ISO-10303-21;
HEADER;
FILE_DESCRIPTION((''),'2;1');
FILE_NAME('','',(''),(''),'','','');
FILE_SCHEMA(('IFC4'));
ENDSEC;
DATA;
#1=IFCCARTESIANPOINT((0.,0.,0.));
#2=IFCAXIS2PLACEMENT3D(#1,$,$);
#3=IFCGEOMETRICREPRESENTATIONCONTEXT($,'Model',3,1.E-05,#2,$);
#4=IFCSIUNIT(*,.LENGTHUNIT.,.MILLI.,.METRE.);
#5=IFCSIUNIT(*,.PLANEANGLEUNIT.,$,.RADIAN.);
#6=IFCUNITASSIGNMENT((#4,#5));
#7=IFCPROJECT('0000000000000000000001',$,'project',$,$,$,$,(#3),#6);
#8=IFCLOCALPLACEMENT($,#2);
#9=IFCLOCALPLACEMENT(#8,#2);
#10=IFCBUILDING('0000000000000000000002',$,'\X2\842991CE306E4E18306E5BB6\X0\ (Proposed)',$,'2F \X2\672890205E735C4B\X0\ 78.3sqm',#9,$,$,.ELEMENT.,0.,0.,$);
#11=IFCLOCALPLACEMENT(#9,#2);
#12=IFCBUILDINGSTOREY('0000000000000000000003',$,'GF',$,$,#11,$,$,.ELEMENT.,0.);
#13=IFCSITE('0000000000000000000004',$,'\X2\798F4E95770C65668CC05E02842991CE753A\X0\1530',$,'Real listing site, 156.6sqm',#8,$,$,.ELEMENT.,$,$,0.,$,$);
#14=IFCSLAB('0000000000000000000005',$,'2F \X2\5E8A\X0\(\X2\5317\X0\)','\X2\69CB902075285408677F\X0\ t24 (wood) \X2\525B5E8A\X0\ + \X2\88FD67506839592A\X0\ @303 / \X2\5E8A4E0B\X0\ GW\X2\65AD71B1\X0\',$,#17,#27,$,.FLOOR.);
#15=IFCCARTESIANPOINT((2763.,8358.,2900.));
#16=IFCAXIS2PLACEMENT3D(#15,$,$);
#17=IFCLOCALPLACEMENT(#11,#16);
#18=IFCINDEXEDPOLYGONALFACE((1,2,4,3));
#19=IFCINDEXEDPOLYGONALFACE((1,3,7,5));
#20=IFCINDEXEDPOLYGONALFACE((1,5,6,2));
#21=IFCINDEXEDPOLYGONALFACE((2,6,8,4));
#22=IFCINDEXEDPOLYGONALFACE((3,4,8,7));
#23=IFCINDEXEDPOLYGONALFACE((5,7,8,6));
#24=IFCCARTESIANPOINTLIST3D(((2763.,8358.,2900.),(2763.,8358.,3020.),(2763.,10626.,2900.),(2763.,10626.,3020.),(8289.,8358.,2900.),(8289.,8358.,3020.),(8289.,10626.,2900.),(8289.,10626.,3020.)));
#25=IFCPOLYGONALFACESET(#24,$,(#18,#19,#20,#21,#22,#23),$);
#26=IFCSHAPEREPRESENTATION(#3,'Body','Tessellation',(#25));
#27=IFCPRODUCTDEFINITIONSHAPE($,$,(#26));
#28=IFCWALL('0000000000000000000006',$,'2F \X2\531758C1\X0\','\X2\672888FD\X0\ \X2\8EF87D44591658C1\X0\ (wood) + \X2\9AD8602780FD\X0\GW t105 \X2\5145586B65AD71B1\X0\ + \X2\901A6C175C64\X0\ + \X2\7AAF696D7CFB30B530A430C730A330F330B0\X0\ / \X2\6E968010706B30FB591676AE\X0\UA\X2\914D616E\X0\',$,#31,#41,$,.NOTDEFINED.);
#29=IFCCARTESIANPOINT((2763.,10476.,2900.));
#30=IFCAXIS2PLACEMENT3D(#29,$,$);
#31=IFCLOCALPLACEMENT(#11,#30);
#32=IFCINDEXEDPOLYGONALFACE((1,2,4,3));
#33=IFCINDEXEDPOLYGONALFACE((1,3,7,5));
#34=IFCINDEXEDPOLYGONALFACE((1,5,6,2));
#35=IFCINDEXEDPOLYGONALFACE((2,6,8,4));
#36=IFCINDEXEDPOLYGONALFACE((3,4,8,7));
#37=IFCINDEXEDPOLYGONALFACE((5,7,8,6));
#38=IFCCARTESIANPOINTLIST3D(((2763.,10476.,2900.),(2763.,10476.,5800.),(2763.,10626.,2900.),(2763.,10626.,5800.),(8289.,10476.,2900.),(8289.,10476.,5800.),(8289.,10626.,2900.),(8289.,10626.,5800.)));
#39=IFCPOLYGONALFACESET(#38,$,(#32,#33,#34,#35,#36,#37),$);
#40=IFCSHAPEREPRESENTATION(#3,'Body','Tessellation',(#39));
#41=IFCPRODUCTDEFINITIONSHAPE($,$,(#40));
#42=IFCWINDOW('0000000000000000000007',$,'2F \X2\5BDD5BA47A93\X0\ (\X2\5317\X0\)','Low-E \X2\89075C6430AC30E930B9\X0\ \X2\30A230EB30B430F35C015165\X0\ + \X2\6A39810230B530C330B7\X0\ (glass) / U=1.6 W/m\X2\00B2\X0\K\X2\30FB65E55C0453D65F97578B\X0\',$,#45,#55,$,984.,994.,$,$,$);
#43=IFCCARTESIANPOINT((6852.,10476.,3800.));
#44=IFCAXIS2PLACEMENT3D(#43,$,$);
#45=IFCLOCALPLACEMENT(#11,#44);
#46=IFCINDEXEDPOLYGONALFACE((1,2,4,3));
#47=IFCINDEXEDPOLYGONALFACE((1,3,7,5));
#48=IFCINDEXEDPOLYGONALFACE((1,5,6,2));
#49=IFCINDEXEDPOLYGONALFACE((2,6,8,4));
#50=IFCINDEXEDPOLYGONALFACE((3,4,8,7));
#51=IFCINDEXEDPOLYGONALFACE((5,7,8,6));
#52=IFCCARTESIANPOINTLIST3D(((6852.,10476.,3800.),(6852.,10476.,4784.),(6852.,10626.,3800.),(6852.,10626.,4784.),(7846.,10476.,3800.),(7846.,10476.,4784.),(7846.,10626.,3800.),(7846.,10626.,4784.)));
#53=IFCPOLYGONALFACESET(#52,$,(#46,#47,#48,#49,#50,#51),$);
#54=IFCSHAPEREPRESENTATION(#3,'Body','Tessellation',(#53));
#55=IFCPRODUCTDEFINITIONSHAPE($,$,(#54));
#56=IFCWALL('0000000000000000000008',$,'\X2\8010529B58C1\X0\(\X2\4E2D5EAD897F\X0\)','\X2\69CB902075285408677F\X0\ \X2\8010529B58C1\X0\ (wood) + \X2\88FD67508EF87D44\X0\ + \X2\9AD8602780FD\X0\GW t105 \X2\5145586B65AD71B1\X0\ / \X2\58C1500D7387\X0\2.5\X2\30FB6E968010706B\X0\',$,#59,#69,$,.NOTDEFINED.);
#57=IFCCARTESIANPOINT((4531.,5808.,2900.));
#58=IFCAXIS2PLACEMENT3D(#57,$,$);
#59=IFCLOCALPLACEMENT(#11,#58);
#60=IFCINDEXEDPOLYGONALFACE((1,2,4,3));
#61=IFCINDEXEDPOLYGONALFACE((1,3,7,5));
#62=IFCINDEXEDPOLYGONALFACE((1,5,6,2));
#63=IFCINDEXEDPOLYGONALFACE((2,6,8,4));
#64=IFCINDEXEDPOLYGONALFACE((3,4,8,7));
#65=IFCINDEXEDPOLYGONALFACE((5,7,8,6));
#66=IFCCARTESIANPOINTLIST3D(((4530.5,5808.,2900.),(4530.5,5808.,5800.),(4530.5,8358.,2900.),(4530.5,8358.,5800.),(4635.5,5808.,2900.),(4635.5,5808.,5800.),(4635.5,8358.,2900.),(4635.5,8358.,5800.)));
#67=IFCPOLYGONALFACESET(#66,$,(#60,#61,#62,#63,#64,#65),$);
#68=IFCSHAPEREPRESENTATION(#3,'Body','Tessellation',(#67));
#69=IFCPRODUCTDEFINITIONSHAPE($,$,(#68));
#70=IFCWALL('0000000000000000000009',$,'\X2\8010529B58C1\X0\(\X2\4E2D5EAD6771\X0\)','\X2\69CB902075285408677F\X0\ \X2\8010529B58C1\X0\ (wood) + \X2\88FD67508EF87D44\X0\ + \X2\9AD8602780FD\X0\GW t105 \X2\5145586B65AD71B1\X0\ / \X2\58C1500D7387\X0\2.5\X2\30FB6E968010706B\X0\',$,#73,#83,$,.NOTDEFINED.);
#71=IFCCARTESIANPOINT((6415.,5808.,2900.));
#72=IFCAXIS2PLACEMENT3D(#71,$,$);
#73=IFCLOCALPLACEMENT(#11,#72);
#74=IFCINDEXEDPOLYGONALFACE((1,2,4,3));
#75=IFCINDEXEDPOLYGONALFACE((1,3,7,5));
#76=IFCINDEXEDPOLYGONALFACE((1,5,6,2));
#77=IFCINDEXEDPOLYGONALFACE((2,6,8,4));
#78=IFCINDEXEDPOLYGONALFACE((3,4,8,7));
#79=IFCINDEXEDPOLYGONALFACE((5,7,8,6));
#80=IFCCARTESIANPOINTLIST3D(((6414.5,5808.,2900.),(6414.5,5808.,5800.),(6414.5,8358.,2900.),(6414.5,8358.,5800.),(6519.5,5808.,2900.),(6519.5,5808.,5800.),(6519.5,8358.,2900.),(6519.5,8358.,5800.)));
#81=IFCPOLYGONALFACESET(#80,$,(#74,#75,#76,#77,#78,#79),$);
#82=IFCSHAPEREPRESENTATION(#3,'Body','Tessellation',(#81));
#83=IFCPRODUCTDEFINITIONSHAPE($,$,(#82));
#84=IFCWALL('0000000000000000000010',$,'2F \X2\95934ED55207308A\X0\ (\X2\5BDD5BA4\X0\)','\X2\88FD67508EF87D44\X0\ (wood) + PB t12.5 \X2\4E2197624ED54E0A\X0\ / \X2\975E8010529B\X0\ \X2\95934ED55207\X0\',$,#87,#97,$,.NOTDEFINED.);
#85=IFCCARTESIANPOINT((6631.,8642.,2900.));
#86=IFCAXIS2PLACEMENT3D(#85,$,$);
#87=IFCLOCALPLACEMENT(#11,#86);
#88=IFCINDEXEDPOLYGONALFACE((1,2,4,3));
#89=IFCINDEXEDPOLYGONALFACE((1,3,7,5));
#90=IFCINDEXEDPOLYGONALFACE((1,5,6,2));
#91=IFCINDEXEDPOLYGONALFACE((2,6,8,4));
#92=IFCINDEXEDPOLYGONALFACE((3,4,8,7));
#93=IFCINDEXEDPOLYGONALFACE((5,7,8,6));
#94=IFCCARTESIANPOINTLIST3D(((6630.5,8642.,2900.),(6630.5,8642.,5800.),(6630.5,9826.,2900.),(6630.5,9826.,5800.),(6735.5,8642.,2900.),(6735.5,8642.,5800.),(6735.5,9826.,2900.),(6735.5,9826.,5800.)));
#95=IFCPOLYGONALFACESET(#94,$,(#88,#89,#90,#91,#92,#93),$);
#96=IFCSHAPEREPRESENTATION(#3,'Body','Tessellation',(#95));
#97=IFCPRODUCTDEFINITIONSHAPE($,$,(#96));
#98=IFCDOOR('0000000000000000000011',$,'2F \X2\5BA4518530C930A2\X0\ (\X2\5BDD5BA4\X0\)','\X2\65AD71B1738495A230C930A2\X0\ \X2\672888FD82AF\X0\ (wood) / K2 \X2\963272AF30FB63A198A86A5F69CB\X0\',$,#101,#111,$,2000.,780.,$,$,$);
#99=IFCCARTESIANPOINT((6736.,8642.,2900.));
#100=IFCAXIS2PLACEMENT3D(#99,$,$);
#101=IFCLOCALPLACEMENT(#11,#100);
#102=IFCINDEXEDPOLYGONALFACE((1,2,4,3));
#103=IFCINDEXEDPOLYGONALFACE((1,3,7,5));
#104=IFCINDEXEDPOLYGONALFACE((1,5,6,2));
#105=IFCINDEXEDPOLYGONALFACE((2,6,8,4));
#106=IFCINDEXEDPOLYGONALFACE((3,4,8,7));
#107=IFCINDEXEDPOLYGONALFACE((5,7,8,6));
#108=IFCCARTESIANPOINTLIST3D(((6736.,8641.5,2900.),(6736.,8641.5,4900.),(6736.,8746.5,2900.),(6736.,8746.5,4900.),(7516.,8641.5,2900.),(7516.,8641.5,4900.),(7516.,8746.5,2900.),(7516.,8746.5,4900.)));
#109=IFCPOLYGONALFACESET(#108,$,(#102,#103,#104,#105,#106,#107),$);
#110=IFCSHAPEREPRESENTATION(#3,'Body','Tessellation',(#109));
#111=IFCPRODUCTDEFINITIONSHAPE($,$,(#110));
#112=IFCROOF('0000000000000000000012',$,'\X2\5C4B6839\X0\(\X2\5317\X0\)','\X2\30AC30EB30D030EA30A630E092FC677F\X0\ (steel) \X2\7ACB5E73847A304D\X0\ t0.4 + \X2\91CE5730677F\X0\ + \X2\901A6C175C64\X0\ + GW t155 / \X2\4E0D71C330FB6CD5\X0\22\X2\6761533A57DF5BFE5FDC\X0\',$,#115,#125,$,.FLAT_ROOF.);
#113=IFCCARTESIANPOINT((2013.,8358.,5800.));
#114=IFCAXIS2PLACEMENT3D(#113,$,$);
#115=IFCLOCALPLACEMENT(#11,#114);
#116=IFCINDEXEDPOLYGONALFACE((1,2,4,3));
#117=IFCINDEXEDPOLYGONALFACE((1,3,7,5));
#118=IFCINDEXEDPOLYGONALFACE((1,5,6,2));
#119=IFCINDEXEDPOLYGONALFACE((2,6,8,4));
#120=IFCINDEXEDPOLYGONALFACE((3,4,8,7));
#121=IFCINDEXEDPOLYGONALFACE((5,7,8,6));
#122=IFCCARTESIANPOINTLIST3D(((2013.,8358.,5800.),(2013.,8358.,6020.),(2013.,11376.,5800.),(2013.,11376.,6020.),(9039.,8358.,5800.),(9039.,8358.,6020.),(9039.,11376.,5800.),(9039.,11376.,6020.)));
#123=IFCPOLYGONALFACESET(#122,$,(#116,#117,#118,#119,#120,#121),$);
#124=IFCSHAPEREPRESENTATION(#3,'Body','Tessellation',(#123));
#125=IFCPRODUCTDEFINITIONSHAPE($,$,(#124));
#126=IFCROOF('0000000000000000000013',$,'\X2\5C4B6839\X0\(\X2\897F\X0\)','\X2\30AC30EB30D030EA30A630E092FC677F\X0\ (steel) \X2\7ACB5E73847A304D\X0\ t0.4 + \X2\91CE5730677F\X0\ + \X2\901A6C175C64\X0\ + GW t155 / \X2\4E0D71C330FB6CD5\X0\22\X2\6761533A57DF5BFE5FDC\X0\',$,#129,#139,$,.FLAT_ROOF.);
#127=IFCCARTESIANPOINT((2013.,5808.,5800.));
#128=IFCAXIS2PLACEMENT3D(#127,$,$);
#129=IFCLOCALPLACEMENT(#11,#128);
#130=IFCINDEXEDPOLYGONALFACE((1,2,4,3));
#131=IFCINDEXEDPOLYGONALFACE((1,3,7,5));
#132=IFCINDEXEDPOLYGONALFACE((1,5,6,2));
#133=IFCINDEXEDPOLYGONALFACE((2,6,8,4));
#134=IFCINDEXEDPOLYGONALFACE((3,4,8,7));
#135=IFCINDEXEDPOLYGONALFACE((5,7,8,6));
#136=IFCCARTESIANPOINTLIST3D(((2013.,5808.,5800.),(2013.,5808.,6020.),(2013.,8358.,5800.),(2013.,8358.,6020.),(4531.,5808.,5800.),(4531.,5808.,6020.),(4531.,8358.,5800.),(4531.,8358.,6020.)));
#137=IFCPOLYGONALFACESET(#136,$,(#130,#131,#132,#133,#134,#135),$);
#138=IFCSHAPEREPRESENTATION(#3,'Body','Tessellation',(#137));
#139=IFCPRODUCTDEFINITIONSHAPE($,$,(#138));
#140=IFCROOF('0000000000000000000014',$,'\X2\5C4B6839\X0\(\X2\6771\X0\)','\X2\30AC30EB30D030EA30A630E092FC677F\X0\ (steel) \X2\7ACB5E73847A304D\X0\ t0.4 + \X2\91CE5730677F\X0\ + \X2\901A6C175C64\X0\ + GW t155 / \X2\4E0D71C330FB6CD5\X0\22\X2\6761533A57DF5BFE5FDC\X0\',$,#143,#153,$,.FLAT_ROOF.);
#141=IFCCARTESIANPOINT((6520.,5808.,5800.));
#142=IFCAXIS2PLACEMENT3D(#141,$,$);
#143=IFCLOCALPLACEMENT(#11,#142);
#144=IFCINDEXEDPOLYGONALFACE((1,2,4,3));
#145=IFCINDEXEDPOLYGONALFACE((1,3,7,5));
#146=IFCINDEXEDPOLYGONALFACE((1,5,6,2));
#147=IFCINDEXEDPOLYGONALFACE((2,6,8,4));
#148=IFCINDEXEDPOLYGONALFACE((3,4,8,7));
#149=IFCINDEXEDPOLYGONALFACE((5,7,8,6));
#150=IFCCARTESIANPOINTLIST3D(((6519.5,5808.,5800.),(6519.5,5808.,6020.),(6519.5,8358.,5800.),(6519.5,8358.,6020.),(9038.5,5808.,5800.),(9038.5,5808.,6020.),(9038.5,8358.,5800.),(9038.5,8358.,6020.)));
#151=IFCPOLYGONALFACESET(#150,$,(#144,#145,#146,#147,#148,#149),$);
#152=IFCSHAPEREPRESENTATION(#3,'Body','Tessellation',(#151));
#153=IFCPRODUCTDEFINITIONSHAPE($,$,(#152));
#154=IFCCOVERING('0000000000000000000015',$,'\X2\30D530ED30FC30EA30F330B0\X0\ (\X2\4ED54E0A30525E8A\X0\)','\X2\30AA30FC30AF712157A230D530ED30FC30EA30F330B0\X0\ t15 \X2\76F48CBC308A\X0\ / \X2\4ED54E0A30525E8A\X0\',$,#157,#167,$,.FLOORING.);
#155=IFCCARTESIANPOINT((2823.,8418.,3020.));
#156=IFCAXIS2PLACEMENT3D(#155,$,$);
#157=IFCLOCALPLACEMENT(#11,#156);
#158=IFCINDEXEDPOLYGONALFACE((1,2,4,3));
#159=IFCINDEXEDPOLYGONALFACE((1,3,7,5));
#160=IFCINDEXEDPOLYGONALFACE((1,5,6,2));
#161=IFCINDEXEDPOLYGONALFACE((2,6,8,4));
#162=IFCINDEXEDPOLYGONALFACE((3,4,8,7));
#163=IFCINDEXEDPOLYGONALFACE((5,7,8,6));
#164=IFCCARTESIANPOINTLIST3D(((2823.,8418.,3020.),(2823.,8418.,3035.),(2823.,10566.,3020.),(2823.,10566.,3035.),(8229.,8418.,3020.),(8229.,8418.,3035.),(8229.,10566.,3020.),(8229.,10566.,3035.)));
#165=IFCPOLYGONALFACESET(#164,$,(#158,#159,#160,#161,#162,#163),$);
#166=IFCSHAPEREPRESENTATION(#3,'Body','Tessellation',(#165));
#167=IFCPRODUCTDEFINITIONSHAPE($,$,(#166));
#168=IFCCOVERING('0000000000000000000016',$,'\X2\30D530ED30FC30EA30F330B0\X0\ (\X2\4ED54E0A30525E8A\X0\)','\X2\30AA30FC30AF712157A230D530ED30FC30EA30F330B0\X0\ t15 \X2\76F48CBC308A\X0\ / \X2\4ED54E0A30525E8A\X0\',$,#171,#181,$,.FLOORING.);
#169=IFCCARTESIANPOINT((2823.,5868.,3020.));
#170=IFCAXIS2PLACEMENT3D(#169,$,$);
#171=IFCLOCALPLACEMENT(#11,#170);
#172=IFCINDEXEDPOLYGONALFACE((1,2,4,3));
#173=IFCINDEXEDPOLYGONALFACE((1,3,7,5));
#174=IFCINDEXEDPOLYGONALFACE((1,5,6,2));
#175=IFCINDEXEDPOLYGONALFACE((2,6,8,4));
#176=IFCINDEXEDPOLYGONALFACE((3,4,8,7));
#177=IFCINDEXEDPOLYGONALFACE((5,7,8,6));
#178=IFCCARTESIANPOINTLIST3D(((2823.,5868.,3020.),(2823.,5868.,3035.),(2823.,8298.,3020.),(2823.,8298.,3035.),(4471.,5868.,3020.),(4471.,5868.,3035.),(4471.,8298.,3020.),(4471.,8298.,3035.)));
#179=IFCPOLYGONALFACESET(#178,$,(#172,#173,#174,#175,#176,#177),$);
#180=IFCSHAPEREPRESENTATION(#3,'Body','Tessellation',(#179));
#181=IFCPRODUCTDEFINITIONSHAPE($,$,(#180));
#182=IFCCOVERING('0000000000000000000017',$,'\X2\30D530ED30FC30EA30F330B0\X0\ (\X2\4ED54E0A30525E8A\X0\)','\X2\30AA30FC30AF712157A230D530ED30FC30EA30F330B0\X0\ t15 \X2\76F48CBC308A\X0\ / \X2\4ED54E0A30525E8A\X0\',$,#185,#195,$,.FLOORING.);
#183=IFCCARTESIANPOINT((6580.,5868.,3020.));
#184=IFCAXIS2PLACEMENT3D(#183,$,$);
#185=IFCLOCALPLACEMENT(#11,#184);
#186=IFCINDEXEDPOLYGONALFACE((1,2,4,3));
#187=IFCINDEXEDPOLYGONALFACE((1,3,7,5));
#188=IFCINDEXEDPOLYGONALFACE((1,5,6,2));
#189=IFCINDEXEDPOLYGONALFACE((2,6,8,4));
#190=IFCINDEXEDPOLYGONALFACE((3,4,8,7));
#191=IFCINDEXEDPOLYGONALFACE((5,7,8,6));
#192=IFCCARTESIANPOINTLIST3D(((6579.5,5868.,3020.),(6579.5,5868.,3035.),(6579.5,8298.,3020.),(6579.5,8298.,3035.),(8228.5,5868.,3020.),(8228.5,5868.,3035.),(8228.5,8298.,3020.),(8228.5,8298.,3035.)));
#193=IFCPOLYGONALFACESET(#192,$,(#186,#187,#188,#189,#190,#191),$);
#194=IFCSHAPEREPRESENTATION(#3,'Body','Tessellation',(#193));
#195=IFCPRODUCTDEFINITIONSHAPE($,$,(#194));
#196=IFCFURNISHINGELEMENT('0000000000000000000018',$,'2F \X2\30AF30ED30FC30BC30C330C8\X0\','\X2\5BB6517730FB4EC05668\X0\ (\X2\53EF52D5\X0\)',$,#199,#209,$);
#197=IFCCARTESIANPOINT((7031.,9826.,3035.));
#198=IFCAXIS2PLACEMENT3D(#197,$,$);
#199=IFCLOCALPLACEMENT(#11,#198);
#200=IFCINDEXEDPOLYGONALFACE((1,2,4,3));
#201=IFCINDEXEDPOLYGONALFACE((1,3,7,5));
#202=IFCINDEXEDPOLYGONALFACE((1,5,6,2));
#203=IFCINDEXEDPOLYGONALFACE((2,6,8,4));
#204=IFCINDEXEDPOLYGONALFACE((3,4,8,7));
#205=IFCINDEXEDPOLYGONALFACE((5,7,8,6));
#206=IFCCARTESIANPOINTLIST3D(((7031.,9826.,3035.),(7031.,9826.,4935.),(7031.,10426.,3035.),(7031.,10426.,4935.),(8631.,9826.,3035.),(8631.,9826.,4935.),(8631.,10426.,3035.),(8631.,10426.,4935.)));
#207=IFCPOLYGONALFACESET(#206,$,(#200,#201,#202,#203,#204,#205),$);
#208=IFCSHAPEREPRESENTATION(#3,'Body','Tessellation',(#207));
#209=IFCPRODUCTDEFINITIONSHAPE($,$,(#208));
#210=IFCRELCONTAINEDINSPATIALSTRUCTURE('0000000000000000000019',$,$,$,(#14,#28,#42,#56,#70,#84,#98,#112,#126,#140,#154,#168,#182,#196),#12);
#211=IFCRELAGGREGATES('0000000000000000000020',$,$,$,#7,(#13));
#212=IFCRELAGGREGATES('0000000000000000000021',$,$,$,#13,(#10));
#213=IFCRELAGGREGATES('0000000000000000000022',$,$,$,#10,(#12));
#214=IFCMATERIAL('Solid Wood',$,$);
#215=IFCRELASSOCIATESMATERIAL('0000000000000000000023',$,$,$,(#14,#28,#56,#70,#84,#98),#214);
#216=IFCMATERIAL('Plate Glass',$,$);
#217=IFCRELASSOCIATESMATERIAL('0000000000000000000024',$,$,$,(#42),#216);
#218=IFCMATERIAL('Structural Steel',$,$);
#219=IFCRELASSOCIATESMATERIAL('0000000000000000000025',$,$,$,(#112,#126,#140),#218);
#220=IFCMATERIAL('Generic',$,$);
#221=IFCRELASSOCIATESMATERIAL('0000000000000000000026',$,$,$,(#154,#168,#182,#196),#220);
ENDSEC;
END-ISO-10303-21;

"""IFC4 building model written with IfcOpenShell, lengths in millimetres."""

from ifc_helpers import new_model, si_unit, frame, frame_2d, origin, place, context, project, spatial, rectangle, extrude, material, element, fill, save


model = new_model("IFC4")

# Units and contexts
model_context = context("Model", 3, precision=1e-05, world=origin())
ifc_project = project(units=[si_unit("LENGTHUNIT", "METRE", prefix="MILLI"), si_unit("PLANEANGLEUNIT", "RADIAN")], contexts=[model_context])

# Site, building, storey
site_placement = place(None, origin())
site = spatial("IfcSite", under=ifc_project, at=site_placement, Name="福井県敦賀市萩野町1530", ObjectType="Real listing site, 156.6sqm", CompositionType="ELEMENT", RefElevation=0.0)
building_placement = place(site_placement, origin())
building = spatial("IfcBuilding", under=site, at=building_placement, Name="萩野の丘の家 (Proposed)", ObjectType="2F 木造平屋 78.3sqm", CompositionType="ELEMENT", ElevationOfRefHeight=0.0, ElevationOfTerrain=0.0)
storey_placement = place(building_placement, origin())
storey = spatial("IfcBuildingStorey", under=building, at=storey_placement, Name="GF", CompositionType="ELEMENT", Elevation=0.0)

# Slab
ifc_material_1 = material(Name="Solid Wood")
slab_placement = place(storey_placement, frame((2763.0, 8358.0, 2900.0)))
element("IfcSlab", 1, at=slab_placement, inside=storey, material=ifc_material_1, Name="2F 床(北)", Description="構造用合板 t24 (wood) 剛床 + 製材根太 @303 / 床下 GW断熱", PredefinedType="FLOOR", context=model_context, shape_type="SweptSolid", body=[
    extrude(rectangle(XDim=5526.0, YDim=2268.0, at=frame_2d((2763.0, 1134.0))), frame((2763.0, 8358.0, 2900.0)), (0.0, 0.0, 1.0), 120.0),
])

# Wall, opening, window
wall_1_placement = place(storey_placement, frame((2763.0, 10476.0, 2900.0)))
wall_1 = element("IfcWall", 2, at=wall_1_placement, inside=storey, material=ifc_material_1, Name="2F 北壁", Description="木製 軸組外壁 (wood) + 高性能GW t105 充填断熱 + 通気層 + 窯業系サイディング / 準耐火・外皮UA配慮", PredefinedType="NOTDEFINED", context=model_context, shape_type="SweptSolid", body=[
    extrude(rectangle(XDim=5526.0, YDim=150.0, at=frame_2d((2763.0, 75.0))), frame((2763.0, 10476.0, 2900.0)), (0.0, 0.0, 1.0), 2900.0),
])
opening_1_placement = place(storey_placement, frame((6852.0, 10476.0, 3800.0)))
opening_1 = element("IfcOpeningElement", 3, at=opening_1_placement, cuts=wall_1, PredefinedType="NOTDEFINED", context=model_context, shape_type="SweptSolid", body=[
    extrude(rectangle(XDim=994.0, YDim=150.0, at=frame_2d((497.0, 75.0))), frame((6852.0, 10476.0, 3800.0)), (0.0, 0.0, 1.0), 984.0),
])
ifc_material_2 = material(Name="Plate Glass")
window_1_placement = place(storey_placement, frame((6852.0, 10476.0, 3800.0)))
window_1 = element("IfcWindow", 4, at=window_1_placement, inside=storey, material=ifc_material_2, Name="2F 寝室窓 (北)", Description="Low-E 複層ガラス アルゴン封入 + 樹脂サッシ (glass) / U=1.6 W/m²K・日射取得型", OverallHeight=984.0, OverallWidth=994.0, context=model_context, shape_type="SweptSolid", body=[
    extrude(rectangle(XDim=994.0, YDim=150.0, at=frame_2d((497.0, 75.0))), frame((6852.0, 10476.0, 3800.0)), (0.0, 0.0, 1.0), 984.0),
])
fill(opening_1, window_1)

# Walls
wall_2_placement = place(storey_placement, frame((4531.0, 5808.0, 2900.0)))
element("IfcWall", 5, at=wall_2_placement, inside=storey, material=ifc_material_1, Name="耐力壁(中庭西)", Description="構造用合板 耐力壁 (wood) + 製材軸組 + 高性能GW t105 充填断熱 / 壁倍率2.5・準耐火", PredefinedType="NOTDEFINED", context=model_context, shape_type="SweptSolid", body=[
    extrude(rectangle(XDim=105.0, YDim=2550.0, at=frame_2d((52.0, 1275.0))), frame((4531.0, 5808.0, 2900.0)), (0.0, 0.0, 1.0), 2900.0),
])
wall_3_placement = place(storey_placement, frame((6415.0, 5808.0, 2900.0)))
element("IfcWall", 6, at=wall_3_placement, inside=storey, material=ifc_material_1, Name="耐力壁(中庭東)", Description="構造用合板 耐力壁 (wood) + 製材軸組 + 高性能GW t105 充填断熱 / 壁倍率2.5・準耐火", PredefinedType="NOTDEFINED", context=model_context, shape_type="SweptSolid", body=[
    extrude(rectangle(XDim=105.0, YDim=2550.0, at=frame_2d((52.0, 1275.0))), frame((6415.0, 5808.0, 2900.0)), (0.0, 0.0, 1.0), 2900.0),
])
wall_4_placement = place(storey_placement, frame((6631.0, 8642.0, 2900.0)))
element("IfcWall", 7, at=wall_4_placement, inside=storey, material=ifc_material_1, Name="2F 間仕切り (寝室)", Description="製材軸組 (wood) + PB t12.5 両面仕上 / 非耐力 間仕切", PredefinedType="NOTDEFINED", context=model_context, shape_type="SweptSolid", body=[
    extrude(rectangle(XDim=105.0, YDim=1184.0, at=frame_2d((52.0, 592.0))), frame((6631.0, 8642.0, 2900.0)), (0.0, 0.0, 1.0), 2900.0),
])

# Door
door_placement = place(storey_placement, frame((6736.0, 8642.0, 2900.0)))
element("IfcDoor", 8, at=door_placement, inside=storey, material=ifc_material_1, Name="2F 室内ドア (寝室)", Description="断熱玄関ドア 木製芯 (wood) / K2 防犯・採風機構", OverallHeight=2000.0, OverallWidth=780.0, context=model_context, shape_type="SweptSolid", body=[
    extrude(rectangle(XDim=780.0, YDim=105.0, at=frame_2d((390.0, 52.0))), frame((6736.0, 8642.0, 2900.0)), (0.0, 0.0, 1.0), 2000.0),
])

# Roofs
ifc_material_3 = material(Name="Structural Steel")
for number, where, name in (
    (9, (2013.0, 8358.0, 5800.0), "屋根(北)"),
):
    element("IfcRoof", number, at=place(storey_placement, frame(where)), inside=storey, material=ifc_material_3, Name=name, Description="ガルバリウム鋼板 (steel) 立平葺き t0.4 + 野地板 + 通気層 + GW t155 / 不燃・法22条区域対応", PredefinedType="FLAT_ROOF", context=model_context, shape_type="SweptSolid", body=[
        extrude(rectangle(XDim=7026.0, YDim=3018.0, at=frame_2d((3513.0, 1509.0))), frame((2013.0, 8358.0, 5800.0)), (0.0, 0.0, 1.0), 220.0),
    ])
roof_1_placement = place(storey_placement, frame((2013.0, 5808.0, 5800.0)))
element("IfcRoof", 10, at=roof_1_placement, inside=storey, material=ifc_material_3, Name="屋根(西)", Description="ガルバリウム鋼板 (steel) 立平葺き t0.4 + 野地板 + 通気層 + GW t155 / 不燃・法22条区域対応", PredefinedType="FLAT_ROOF", context=model_context, shape_type="SweptSolid", body=[
    extrude(rectangle(XDim=2518.0, YDim=2550.0, at=frame_2d((1259.0, 1275.0))), frame((2013.0, 5808.0, 5800.0)), (0.0, 0.0, 1.0), 220.0),
])
roof_2_placement = place(storey_placement, frame((6520.0, 5808.0, 5800.0)))
element("IfcRoof", 11, at=roof_2_placement, inside=storey, material=ifc_material_3, Name="屋根(東)", Description="ガルバリウム鋼板 (steel) 立平葺き t0.4 + 野地板 + 通気層 + GW t155 / 不燃・法22条区域対応", PredefinedType="FLAT_ROOF", context=model_context, shape_type="SweptSolid", body=[
    extrude(rectangle(XDim=2519.0, YDim=2550.0, at=frame_2d((1259.0, 1275.0))), frame((6520.0, 5808.0, 5800.0)), (0.0, 0.0, 1.0), 220.0),
])

# Coverings
ifc_material_4 = material(Name="Generic")
covering_1_placement = place(storey_placement, frame((2823.0, 8418.0, 3020.0)))
element("IfcCovering", 12, at=covering_1_placement, inside=storey, material=ifc_material_4, Name="フローリング (仕上げ床)", Description="オーク無垢フローリング t15 直貼り / 仕上げ床", PredefinedType="FLOORING", context=model_context, shape_type="SweptSolid", body=[
    extrude(rectangle(XDim=5406.0, YDim=2148.0, at=frame_2d((2703.0, 1074.0))), frame((2823.0, 8418.0, 3020.0)), (0.0, 0.0, 1.0), 15.0),
])
covering_2_placement = place(storey_placement, frame((2823.0, 5868.0, 3020.0)))
element("IfcCovering", 13, at=covering_2_placement, inside=storey, material=ifc_material_4, Name="フローリング (仕上げ床)", Description="オーク無垢フローリング t15 直貼り / 仕上げ床", PredefinedType="FLOORING", context=model_context, shape_type="SweptSolid", body=[
    extrude(rectangle(XDim=1648.0, YDim=2430.0, at=frame_2d((824.0, 1215.0))), frame((2823.0, 5868.0, 3020.0)), (0.0, 0.0, 1.0), 15.0),
])
covering_3_placement = place(storey_placement, frame((6580.0, 5868.0, 3020.0)))
element("IfcCovering", 14, at=covering_3_placement, inside=storey, material=ifc_material_4, Name="フローリング (仕上げ床)", Description="オーク無垢フローリング t15 直貼り / 仕上げ床", PredefinedType="FLOORING", context=model_context, shape_type="SweptSolid", body=[
    extrude(rectangle(XDim=1649.0, YDim=2430.0, at=frame_2d((824.0, 1215.0))), frame((6580.0, 5868.0, 3020.0)), (0.0, 0.0, 1.0), 15.0),
])

# Furnishing element
furnishing_1_placement = place(storey_placement, frame((7031.0, 9826.0, 3035.0)))
element("IfcFurnishingElement", 15, at=furnishing_1_placement, inside=storey, material=ifc_material_4, Name="2F クローゼット", Description="家具・什器 (可動)", context=model_context, shape_type="SweptSolid", body=[
    extrude(rectangle(XDim=1600.0, YDim=600.0, at=frame_2d((800.0, 300.0))), frame((7031.0, 9826.0, 3035.0)), (0.0, 0.0, 1.0), 1900.0),
])

save(model, "model.ifc")
